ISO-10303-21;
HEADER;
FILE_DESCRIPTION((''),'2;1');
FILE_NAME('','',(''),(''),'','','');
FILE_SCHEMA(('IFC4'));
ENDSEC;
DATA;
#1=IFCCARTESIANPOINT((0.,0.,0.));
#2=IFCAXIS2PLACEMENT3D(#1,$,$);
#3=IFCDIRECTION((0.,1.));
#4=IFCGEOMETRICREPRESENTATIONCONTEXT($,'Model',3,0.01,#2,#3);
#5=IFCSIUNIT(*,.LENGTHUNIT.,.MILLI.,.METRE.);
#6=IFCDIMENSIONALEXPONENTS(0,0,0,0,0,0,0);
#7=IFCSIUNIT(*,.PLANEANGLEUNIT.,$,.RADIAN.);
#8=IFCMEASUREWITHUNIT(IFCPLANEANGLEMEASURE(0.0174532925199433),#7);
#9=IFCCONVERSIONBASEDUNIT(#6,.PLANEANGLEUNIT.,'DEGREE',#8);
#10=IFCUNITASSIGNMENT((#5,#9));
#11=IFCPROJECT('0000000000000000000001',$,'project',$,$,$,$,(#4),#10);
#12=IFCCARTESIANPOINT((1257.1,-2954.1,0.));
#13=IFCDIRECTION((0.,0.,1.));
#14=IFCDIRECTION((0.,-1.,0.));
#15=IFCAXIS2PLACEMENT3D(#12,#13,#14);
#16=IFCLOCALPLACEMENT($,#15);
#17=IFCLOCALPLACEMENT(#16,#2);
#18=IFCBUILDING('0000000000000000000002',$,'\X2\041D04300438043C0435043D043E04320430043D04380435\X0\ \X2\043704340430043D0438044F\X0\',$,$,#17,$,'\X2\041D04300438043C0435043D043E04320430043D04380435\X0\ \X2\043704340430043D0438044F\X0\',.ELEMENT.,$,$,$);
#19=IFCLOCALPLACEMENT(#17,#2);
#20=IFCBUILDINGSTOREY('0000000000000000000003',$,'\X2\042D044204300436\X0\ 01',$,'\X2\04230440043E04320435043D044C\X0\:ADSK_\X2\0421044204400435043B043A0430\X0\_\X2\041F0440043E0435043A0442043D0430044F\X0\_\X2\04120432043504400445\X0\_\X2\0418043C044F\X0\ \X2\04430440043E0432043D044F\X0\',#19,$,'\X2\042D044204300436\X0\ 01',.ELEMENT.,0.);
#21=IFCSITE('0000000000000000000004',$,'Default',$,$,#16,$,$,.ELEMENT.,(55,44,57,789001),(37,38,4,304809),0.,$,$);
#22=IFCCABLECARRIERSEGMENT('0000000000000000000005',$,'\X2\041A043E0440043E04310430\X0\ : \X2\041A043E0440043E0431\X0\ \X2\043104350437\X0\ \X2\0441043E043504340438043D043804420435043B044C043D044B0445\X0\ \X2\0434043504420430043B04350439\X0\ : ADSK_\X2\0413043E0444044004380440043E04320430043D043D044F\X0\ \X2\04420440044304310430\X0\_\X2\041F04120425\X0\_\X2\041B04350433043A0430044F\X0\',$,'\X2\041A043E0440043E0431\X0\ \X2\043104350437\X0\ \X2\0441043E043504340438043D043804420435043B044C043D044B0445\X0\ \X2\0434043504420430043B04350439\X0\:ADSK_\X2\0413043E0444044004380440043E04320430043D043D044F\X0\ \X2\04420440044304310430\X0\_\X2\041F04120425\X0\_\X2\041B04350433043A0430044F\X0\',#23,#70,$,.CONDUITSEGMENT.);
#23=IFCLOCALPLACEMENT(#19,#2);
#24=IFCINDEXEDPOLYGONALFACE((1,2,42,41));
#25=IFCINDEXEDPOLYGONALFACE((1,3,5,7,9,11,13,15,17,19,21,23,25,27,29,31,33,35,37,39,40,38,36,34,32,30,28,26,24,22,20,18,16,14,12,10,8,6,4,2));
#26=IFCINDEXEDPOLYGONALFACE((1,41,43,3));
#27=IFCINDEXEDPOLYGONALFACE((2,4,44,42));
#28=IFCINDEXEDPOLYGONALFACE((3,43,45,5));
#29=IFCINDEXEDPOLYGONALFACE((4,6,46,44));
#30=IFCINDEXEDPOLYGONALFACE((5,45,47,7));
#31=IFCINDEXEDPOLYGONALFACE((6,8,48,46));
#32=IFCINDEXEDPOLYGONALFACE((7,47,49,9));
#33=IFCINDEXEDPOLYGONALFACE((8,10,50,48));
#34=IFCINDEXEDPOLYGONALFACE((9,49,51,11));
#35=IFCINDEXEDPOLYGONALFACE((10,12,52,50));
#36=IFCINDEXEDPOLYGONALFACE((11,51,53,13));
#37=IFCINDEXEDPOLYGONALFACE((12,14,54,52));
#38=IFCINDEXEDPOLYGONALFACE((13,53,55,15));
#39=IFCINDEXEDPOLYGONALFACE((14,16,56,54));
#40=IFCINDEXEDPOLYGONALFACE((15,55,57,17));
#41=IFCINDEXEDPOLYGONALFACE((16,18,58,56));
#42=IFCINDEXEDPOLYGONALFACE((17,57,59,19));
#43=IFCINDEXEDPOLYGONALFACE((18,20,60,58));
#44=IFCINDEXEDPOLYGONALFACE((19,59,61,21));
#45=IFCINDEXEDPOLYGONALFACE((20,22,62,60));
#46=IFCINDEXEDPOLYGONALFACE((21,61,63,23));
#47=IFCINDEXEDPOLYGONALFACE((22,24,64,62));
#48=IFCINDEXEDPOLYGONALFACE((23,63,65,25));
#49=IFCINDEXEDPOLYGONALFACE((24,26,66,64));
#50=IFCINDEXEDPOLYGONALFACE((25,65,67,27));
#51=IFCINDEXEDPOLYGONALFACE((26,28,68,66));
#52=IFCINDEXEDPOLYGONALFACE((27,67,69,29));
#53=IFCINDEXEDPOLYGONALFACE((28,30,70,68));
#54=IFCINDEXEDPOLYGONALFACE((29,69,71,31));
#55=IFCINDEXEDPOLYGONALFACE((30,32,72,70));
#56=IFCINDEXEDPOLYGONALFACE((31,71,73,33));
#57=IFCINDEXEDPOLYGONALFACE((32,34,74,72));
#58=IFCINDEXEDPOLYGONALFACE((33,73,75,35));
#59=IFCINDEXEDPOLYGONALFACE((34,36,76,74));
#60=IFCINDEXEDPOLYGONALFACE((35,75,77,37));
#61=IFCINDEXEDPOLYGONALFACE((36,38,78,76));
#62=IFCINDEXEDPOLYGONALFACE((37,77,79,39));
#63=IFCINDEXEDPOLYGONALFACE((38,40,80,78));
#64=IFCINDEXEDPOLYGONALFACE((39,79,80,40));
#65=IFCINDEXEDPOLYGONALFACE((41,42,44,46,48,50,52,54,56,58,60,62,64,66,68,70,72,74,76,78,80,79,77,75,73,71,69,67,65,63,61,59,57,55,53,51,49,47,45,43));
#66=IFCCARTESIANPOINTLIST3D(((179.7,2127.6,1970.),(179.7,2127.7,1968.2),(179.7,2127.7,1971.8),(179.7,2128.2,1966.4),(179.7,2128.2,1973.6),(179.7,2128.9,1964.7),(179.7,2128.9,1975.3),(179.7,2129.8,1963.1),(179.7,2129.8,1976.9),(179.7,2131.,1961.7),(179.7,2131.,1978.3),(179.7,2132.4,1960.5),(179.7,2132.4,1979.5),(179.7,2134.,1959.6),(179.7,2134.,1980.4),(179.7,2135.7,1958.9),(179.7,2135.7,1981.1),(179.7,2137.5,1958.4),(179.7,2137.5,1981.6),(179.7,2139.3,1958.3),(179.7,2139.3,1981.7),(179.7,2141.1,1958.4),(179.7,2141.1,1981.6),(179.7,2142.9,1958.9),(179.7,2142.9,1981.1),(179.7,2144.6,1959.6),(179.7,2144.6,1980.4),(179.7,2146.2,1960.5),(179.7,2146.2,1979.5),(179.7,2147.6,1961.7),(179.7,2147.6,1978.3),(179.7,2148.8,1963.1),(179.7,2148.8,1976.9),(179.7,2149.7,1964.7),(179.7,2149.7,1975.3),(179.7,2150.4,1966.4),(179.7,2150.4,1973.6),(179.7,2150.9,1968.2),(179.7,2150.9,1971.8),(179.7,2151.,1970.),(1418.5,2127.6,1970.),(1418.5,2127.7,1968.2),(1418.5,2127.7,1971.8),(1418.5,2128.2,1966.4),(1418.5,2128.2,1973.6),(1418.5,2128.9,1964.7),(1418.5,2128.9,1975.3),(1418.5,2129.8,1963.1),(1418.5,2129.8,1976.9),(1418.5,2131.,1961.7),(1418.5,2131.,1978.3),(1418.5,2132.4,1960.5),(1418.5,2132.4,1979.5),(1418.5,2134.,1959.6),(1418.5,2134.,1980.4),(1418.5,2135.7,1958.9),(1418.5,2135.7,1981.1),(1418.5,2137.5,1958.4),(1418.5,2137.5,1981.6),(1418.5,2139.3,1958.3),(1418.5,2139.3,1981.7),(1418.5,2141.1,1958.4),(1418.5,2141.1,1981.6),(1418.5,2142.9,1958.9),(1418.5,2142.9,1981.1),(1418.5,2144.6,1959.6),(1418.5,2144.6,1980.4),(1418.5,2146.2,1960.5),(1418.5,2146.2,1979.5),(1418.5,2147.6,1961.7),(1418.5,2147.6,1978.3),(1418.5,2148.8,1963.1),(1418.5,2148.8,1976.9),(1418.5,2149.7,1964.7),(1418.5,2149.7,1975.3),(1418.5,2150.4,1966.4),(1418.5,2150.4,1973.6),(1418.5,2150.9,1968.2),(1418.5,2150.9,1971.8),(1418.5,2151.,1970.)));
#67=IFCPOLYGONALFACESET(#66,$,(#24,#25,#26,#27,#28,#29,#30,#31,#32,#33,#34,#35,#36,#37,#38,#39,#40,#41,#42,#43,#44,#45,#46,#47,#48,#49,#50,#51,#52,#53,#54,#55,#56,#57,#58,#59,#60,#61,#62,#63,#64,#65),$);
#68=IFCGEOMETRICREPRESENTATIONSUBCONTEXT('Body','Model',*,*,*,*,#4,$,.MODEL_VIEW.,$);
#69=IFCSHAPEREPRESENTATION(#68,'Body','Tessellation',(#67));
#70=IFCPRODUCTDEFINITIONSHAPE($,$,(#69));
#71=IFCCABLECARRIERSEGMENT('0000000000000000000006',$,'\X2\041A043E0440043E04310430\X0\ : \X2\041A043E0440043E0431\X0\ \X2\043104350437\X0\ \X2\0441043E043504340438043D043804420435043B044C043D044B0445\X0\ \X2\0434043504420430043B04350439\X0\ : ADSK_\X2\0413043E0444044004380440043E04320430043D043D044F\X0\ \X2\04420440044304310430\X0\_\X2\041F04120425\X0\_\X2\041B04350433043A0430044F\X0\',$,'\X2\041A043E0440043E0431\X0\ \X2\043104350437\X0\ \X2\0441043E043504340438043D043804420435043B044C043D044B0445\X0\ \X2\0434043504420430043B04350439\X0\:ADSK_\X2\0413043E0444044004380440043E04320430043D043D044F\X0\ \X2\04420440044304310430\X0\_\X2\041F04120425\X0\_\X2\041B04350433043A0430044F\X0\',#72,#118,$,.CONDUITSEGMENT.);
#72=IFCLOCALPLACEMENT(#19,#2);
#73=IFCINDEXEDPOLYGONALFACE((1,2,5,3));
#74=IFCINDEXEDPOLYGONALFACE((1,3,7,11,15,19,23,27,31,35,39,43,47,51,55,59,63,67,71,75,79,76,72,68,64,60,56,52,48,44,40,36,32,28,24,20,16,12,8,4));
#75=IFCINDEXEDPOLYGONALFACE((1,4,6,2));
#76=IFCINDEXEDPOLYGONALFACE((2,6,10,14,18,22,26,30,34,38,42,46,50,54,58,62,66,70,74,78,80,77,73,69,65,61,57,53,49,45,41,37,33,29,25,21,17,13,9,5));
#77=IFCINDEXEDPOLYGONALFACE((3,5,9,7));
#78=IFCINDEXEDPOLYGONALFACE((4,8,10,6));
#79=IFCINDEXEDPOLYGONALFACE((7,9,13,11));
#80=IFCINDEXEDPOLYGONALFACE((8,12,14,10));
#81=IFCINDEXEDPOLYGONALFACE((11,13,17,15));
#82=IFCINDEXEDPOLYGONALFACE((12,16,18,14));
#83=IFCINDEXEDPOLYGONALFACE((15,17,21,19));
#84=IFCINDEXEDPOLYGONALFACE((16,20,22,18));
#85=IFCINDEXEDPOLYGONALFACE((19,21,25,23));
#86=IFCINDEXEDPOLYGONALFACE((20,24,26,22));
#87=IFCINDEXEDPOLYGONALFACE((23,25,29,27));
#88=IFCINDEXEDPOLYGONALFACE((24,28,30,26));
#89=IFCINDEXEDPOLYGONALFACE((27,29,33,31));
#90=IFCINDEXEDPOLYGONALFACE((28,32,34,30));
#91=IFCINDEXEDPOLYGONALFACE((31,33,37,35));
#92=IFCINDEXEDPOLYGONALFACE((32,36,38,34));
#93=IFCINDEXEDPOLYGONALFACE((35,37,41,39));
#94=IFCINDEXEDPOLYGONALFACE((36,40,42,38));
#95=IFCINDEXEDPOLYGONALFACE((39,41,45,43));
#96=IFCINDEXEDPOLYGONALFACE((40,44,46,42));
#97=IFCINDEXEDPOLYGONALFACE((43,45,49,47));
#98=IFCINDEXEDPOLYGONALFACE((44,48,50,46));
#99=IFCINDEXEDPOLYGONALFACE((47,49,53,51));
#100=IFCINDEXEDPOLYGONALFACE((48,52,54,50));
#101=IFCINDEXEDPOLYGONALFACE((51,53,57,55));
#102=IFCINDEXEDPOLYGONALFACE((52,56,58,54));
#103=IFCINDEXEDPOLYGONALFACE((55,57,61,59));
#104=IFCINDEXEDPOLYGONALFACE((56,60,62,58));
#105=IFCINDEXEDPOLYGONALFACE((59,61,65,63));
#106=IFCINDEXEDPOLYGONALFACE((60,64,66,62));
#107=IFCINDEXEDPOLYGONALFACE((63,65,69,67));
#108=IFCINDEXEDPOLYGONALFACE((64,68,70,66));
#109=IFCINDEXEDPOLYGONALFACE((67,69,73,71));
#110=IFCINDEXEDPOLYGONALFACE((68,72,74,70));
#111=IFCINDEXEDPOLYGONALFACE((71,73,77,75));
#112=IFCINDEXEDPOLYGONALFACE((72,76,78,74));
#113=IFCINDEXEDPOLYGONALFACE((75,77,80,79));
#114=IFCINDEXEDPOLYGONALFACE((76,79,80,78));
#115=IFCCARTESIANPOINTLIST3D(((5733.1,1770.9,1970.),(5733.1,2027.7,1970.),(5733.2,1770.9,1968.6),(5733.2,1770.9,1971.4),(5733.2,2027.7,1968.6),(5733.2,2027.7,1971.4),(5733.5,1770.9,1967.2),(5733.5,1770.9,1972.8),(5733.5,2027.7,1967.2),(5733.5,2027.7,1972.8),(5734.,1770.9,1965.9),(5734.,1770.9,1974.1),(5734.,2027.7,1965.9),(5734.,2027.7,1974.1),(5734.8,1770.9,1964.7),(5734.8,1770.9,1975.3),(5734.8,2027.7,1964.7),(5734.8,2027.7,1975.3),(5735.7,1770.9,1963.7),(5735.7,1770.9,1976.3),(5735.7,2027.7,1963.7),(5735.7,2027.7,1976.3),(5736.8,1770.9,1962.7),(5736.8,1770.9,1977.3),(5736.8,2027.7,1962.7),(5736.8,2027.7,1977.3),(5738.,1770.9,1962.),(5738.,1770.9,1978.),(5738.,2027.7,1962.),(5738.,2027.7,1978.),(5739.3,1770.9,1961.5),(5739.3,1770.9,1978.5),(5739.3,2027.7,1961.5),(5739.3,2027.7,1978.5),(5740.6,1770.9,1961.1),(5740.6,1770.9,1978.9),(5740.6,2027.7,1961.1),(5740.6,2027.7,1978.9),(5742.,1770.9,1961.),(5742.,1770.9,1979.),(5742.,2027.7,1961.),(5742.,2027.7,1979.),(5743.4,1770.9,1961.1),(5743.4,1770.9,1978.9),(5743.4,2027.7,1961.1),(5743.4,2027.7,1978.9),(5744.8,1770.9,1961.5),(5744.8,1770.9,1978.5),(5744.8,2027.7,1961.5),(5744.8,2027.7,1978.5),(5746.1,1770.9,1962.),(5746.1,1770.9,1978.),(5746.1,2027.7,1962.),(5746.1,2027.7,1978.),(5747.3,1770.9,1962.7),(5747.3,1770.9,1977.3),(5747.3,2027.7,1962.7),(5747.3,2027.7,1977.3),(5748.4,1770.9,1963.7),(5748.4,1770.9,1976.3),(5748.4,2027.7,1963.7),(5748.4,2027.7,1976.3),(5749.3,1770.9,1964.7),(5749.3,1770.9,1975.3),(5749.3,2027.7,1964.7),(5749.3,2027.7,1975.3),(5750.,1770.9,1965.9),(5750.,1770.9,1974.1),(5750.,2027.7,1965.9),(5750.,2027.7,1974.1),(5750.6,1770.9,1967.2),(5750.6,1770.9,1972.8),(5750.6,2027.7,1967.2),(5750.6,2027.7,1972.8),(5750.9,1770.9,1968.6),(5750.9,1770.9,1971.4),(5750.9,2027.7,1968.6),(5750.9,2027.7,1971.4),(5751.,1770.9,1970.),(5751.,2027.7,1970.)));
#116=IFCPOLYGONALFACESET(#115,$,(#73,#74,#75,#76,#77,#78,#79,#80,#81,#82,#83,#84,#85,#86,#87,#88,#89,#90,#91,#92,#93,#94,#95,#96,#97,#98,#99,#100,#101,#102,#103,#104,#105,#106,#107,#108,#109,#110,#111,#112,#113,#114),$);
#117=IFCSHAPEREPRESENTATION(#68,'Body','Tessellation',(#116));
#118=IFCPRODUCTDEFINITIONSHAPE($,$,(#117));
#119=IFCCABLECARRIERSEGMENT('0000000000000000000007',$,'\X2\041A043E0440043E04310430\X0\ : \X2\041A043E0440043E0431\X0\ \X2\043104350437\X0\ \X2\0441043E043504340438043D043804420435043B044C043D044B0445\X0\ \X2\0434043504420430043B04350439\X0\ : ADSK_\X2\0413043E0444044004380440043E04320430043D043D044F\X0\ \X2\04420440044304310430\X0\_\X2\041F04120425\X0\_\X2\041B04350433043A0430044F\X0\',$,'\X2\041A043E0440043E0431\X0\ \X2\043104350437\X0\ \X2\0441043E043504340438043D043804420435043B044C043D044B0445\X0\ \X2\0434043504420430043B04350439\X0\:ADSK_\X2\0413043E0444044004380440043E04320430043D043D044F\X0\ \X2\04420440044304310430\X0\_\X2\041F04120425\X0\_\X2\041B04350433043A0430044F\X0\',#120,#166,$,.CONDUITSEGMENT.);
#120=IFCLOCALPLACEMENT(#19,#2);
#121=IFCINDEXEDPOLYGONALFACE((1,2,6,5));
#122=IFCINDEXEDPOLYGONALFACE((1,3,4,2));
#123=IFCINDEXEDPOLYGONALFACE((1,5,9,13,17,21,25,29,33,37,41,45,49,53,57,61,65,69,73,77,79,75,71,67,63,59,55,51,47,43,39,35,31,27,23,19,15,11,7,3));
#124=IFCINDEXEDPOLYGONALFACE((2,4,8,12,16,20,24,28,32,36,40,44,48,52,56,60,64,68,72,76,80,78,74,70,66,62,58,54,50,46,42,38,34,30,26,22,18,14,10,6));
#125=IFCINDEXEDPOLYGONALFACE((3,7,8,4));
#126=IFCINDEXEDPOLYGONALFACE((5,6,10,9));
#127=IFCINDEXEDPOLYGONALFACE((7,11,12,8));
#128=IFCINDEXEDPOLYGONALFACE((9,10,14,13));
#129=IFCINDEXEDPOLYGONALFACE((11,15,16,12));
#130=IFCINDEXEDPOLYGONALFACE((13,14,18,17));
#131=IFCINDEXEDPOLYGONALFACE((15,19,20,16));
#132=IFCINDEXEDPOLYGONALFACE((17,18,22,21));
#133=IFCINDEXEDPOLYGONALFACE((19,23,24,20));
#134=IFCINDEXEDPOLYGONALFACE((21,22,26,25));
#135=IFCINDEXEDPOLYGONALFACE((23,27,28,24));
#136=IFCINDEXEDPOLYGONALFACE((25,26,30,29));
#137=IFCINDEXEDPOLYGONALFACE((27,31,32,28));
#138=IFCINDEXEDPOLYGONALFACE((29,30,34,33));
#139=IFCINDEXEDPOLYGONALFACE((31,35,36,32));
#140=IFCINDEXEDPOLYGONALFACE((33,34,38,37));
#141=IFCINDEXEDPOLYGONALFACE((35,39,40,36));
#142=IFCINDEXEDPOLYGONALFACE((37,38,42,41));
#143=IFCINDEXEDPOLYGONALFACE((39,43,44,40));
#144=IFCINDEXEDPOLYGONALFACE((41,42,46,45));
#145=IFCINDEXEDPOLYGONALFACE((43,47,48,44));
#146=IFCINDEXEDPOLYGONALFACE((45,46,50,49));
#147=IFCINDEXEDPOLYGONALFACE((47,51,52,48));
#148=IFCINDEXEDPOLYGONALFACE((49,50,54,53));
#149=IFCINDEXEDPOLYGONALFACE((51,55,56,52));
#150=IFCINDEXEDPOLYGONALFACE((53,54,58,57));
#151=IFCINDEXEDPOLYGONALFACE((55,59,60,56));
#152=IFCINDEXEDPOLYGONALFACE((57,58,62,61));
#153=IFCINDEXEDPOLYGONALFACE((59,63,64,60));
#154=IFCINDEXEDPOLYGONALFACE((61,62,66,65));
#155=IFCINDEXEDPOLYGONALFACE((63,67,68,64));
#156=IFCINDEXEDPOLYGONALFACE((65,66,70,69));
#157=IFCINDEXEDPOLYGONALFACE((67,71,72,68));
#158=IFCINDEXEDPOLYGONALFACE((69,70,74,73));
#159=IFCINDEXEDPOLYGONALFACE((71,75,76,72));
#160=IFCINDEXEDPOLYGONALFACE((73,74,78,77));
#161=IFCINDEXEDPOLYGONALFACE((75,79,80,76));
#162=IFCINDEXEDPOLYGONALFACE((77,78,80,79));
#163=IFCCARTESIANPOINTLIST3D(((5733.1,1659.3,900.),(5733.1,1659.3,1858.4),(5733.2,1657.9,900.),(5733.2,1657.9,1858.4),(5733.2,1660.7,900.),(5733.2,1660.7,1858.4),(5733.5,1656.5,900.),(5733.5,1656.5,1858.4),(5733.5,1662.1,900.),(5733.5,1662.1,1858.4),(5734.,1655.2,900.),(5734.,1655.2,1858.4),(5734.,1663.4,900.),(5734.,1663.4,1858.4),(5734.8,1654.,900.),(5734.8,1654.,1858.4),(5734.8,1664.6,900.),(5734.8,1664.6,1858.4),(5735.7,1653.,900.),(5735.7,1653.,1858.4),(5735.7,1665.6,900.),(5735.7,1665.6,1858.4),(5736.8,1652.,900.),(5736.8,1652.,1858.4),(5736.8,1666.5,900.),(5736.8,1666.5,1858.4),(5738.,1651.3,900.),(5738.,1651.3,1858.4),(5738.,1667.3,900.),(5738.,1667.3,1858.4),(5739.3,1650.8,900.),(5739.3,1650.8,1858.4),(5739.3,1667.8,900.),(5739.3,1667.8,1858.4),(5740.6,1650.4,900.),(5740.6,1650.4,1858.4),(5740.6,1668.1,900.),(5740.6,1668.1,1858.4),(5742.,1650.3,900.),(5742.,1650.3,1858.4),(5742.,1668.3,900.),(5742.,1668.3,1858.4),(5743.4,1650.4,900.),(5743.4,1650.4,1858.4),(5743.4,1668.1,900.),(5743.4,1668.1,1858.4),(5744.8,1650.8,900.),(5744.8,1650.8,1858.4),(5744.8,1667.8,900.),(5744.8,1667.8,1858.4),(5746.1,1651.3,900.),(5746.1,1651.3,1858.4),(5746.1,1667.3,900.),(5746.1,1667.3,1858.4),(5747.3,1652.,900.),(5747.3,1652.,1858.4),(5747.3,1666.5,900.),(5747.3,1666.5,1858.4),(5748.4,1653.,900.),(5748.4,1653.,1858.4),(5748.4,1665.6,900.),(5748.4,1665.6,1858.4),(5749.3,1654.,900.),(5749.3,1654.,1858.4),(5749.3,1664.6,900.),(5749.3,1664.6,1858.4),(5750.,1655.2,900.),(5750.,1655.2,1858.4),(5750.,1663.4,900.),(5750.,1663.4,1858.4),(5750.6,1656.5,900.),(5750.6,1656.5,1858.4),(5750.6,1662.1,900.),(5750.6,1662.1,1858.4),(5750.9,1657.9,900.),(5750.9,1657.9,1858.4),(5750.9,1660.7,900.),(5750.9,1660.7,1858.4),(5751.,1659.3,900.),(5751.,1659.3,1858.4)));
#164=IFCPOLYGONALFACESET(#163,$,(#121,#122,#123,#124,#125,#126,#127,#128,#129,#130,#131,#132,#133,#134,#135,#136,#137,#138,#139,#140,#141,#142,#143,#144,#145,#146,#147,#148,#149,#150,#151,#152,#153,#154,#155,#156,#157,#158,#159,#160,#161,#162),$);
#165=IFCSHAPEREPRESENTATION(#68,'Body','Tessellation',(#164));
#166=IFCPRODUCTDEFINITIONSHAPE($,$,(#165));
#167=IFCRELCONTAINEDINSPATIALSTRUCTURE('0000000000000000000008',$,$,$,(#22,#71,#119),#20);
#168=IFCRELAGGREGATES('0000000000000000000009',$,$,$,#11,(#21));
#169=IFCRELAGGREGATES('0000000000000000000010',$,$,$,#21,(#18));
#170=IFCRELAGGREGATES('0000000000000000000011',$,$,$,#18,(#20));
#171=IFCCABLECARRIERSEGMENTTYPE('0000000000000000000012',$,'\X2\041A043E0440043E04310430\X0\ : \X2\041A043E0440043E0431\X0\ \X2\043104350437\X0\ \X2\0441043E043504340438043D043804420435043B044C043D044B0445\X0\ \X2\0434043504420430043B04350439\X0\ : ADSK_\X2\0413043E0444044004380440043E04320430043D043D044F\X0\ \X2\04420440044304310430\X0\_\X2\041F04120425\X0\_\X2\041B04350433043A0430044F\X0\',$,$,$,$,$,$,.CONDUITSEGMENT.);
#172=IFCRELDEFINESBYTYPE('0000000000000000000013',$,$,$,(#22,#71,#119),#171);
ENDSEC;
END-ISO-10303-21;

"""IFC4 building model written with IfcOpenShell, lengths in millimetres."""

from ifc_helpers import new_model, entity, si_unit, converted_unit, direction, frame, origin, place, context, subcontext, project, spatial, indexed_curve, outline, extrude, type_object, element, save


model = new_model("IFC4")

# Units and contexts
model_context = context("Model", 3, precision=0.01, world=origin(), true_north=direction((0.0, 1.0)))
body_context = subcontext(model_context, "Body", "Model", "MODEL_VIEW")
ifc_project = project(units=[si_unit("LENGTHUNIT", "METRE", prefix="MILLI"), converted_unit("PLANEANGLEUNIT", "DEGREE", entity("IfcPlaneAngleMeasure", 0.0174532925199433), si_unit("PLANEANGLEUNIT", "RADIAN"), dimensions=[0, 0, 0, 0, 0, 0, 0])], contexts=[model_context])

# Site, building, storey
site_placement = place(None, frame((1257.1, -2954.1, 0.0), z_axis=(0.0, 0.0, 1.0), x_axis=(0.0, -1.0, 0.0)))
site = spatial("IfcSite", under=ifc_project, at=site_placement, Name="Default", CompositionType="ELEMENT", RefLatitude=(55, 44, 57, 789001), RefLongitude=(37, 38, 4, 304809), RefElevation=0.0)
building_placement = place(site_placement, origin())
building = spatial("IfcBuilding", under=site, at=building_placement, Name="Наименование здания", LongName="Наименование здания", CompositionType="ELEMENT")
storey_placement = place(building_placement, origin())
storey = spatial("IfcBuildingStorey", under=building, at=storey_placement, Name="Этаж 01", ObjectType="Уровень:ADSK_Стрелка_Проектная_Вверх_Имя уровня", LongName="Этаж 01", CompositionType="ELEMENT", Elevation=0.0)

# Cable carrier segments
cable_carrier_segment_type = type_object("IfcCableCarrierSegmentType", Name="Короба : Короб без соединительных деталей : ADSK_Гофрировання труба_ПВХ_Легкая", PredefinedType="CONDUITSEGMENT")
cable_carrier_segment_1_placement = place(storey_placement, origin())
element("IfcCableCarrierSegment", 1, at=cable_carrier_segment_1_placement, inside=storey, type_object=cable_carrier_segment_type, Name="Короба : Короб без соединительных деталей : ADSK_Гофрировання труба_ПВХ_Легкая", ObjectType="Короб без соединительных деталей:ADSK_Гофрировання труба_ПВХ_Легкая", PredefinedType="CONDUITSEGMENT", context=body_context, shape_type="SweptSolid", body=[
    extrude(outline(indexed_curve([(11.7, 0.0), (11.6, 1.8), (11.1, 3.6), (10.4, 5.3), (9.5, 6.9), (8.3, 8.3), (6.9, 9.5), (5.3, 10.4), (3.6, 11.1), (1.8, 11.6), (0.0, 11.7), (-1.8, 11.6), (-3.6, 11.1), (-5.3, 10.4), (-6.9, 9.5), (-8.3, 8.3), (-9.5, 6.9), (-10.4, 5.3), (-11.1, 3.6), (-11.6, 1.8), (-11.7, 0.0), (-11.6, -1.8), (-11.1, -3.6), (-10.4, -5.3), (-9.5, -6.9), (-8.3, -8.3), (-6.9, -9.5), (-5.3, -10.4), (-3.6, -11.1), (-1.8, -11.6), (0.0, -11.7), (1.8, -11.6), (3.6, -11.1), (5.3, -10.4), (6.9, -9.5), (8.3, -8.3), (9.5, -6.9), (10.4, -5.3), (11.1, -3.6), (11.6, -1.8), (11.7, 0.0)], self_intersect=False)), frame((179.7, 2139.3, 1970.0), z_axis=(1.0, 0.0, 0.0), x_axis=(0.0, -1.0, 0.0)), (0.0, 0.0, 1.0), 1238.8),
])
cable_carrier_segment_2_placement = place(storey_placement, origin())
element("IfcCableCarrierSegment", 2, at=cable_carrier_segment_2_placement, inside=storey, type_object=cable_carrier_segment_type, Name="Короба : Короб без соединительных деталей : ADSK_Гофрировання труба_ПВХ_Легкая", ObjectType="Короб без соединительных деталей:ADSK_Гофрировання труба_ПВХ_Легкая", PredefinedType="CONDUITSEGMENT", context=body_context, shape_type="SweptSolid", body=[
    extrude(outline(indexed_curve([(9.0, 0.0), (8.9, 1.4), (8.5, 2.8), (8.0, 4.1), (7.3, 5.3), (6.3, 6.3), (5.3, 7.3), (4.1, 8.0), (2.8, 8.5), (1.4, 8.9), (0.0, 9.0), (-1.4, 8.9), (-2.8, 8.5), (-4.1, 8.0), (-5.3, 7.3), (-6.3, 6.3), (-7.3, 5.3), (-8.0, 4.1), (-8.5, 2.8), (-8.9, 1.4), (-9.0, 0.0), (-8.9, -1.4), (-8.5, -2.8), (-8.0, -4.1), (-7.3, -5.3), (-6.3, -6.3), (-5.3, -7.3), (-4.1, -8.0), (-2.8, -8.5), (-1.4, -8.9), (0.0, -9.0), (1.4, -8.9), (2.8, -8.5), (4.1, -8.0), (5.3, -7.3), (6.3, -6.3), (7.3, -5.3), (8.0, -4.1), (8.5, -2.8), (8.9, -1.4), (9.0, 0.0)], self_intersect=False)), frame((5742.0, 1770.9, 1970.0), z_axis=(0.0, 1.0, 0.0), x_axis=(1.0, 0.0, 0.0)), (0.0, 0.0, 1.0), 256.9),
])
cable_carrier_segment_3_placement = place(storey_placement, origin())
element("IfcCableCarrierSegment", 3, at=cable_carrier_segment_3_placement, inside=storey, type_object=cable_carrier_segment_type, Name="Короба : Короб без соединительных деталей : ADSK_Гофрировання труба_ПВХ_Легкая", ObjectType="Короб без соединительных деталей:ADSK_Гофрировання труба_ПВХ_Легкая", PredefinedType="CONDUITSEGMENT", context=body_context, shape_type="SweptSolid", body=[
    extrude(outline(indexed_curve([(9.0, 0.0), (8.9, 1.4), (8.5, 2.8), (8.0, 4.1), (7.3, 5.3), (6.3, 6.3), (5.3, 7.3), (4.1, 8.0), (2.8, 8.5), (1.4, 8.9), (0.0, 9.0), (-1.4, 8.9), (-2.8, 8.5), (-4.1, 8.0), (-5.3, 7.3), (-6.3, 6.3), (-7.3, 5.3), (-8.0, 4.1), (-8.5, 2.8), (-8.9, 1.4), (-9.0, 0.0), (-8.9, -1.4), (-8.5, -2.8), (-8.0, -4.1), (-7.3, -5.3), (-6.3, -6.3), (-5.3, -7.3), (-4.1, -8.0), (-2.8, -8.5), (-1.4, -8.9), (0.0, -9.0), (1.4, -8.9), (2.8, -8.5), (4.1, -8.0), (5.3, -7.3), (6.3, -6.3), (7.3, -5.3), (8.0, -4.1), (8.5, -2.8), (8.9, -1.4), (9.0, 0.0)], self_intersect=False)), frame((5742.0, 1659.3, 900.0)), (0.0, 0.0, 1.0), 958.4),
])

save(model, "model.ifc")
